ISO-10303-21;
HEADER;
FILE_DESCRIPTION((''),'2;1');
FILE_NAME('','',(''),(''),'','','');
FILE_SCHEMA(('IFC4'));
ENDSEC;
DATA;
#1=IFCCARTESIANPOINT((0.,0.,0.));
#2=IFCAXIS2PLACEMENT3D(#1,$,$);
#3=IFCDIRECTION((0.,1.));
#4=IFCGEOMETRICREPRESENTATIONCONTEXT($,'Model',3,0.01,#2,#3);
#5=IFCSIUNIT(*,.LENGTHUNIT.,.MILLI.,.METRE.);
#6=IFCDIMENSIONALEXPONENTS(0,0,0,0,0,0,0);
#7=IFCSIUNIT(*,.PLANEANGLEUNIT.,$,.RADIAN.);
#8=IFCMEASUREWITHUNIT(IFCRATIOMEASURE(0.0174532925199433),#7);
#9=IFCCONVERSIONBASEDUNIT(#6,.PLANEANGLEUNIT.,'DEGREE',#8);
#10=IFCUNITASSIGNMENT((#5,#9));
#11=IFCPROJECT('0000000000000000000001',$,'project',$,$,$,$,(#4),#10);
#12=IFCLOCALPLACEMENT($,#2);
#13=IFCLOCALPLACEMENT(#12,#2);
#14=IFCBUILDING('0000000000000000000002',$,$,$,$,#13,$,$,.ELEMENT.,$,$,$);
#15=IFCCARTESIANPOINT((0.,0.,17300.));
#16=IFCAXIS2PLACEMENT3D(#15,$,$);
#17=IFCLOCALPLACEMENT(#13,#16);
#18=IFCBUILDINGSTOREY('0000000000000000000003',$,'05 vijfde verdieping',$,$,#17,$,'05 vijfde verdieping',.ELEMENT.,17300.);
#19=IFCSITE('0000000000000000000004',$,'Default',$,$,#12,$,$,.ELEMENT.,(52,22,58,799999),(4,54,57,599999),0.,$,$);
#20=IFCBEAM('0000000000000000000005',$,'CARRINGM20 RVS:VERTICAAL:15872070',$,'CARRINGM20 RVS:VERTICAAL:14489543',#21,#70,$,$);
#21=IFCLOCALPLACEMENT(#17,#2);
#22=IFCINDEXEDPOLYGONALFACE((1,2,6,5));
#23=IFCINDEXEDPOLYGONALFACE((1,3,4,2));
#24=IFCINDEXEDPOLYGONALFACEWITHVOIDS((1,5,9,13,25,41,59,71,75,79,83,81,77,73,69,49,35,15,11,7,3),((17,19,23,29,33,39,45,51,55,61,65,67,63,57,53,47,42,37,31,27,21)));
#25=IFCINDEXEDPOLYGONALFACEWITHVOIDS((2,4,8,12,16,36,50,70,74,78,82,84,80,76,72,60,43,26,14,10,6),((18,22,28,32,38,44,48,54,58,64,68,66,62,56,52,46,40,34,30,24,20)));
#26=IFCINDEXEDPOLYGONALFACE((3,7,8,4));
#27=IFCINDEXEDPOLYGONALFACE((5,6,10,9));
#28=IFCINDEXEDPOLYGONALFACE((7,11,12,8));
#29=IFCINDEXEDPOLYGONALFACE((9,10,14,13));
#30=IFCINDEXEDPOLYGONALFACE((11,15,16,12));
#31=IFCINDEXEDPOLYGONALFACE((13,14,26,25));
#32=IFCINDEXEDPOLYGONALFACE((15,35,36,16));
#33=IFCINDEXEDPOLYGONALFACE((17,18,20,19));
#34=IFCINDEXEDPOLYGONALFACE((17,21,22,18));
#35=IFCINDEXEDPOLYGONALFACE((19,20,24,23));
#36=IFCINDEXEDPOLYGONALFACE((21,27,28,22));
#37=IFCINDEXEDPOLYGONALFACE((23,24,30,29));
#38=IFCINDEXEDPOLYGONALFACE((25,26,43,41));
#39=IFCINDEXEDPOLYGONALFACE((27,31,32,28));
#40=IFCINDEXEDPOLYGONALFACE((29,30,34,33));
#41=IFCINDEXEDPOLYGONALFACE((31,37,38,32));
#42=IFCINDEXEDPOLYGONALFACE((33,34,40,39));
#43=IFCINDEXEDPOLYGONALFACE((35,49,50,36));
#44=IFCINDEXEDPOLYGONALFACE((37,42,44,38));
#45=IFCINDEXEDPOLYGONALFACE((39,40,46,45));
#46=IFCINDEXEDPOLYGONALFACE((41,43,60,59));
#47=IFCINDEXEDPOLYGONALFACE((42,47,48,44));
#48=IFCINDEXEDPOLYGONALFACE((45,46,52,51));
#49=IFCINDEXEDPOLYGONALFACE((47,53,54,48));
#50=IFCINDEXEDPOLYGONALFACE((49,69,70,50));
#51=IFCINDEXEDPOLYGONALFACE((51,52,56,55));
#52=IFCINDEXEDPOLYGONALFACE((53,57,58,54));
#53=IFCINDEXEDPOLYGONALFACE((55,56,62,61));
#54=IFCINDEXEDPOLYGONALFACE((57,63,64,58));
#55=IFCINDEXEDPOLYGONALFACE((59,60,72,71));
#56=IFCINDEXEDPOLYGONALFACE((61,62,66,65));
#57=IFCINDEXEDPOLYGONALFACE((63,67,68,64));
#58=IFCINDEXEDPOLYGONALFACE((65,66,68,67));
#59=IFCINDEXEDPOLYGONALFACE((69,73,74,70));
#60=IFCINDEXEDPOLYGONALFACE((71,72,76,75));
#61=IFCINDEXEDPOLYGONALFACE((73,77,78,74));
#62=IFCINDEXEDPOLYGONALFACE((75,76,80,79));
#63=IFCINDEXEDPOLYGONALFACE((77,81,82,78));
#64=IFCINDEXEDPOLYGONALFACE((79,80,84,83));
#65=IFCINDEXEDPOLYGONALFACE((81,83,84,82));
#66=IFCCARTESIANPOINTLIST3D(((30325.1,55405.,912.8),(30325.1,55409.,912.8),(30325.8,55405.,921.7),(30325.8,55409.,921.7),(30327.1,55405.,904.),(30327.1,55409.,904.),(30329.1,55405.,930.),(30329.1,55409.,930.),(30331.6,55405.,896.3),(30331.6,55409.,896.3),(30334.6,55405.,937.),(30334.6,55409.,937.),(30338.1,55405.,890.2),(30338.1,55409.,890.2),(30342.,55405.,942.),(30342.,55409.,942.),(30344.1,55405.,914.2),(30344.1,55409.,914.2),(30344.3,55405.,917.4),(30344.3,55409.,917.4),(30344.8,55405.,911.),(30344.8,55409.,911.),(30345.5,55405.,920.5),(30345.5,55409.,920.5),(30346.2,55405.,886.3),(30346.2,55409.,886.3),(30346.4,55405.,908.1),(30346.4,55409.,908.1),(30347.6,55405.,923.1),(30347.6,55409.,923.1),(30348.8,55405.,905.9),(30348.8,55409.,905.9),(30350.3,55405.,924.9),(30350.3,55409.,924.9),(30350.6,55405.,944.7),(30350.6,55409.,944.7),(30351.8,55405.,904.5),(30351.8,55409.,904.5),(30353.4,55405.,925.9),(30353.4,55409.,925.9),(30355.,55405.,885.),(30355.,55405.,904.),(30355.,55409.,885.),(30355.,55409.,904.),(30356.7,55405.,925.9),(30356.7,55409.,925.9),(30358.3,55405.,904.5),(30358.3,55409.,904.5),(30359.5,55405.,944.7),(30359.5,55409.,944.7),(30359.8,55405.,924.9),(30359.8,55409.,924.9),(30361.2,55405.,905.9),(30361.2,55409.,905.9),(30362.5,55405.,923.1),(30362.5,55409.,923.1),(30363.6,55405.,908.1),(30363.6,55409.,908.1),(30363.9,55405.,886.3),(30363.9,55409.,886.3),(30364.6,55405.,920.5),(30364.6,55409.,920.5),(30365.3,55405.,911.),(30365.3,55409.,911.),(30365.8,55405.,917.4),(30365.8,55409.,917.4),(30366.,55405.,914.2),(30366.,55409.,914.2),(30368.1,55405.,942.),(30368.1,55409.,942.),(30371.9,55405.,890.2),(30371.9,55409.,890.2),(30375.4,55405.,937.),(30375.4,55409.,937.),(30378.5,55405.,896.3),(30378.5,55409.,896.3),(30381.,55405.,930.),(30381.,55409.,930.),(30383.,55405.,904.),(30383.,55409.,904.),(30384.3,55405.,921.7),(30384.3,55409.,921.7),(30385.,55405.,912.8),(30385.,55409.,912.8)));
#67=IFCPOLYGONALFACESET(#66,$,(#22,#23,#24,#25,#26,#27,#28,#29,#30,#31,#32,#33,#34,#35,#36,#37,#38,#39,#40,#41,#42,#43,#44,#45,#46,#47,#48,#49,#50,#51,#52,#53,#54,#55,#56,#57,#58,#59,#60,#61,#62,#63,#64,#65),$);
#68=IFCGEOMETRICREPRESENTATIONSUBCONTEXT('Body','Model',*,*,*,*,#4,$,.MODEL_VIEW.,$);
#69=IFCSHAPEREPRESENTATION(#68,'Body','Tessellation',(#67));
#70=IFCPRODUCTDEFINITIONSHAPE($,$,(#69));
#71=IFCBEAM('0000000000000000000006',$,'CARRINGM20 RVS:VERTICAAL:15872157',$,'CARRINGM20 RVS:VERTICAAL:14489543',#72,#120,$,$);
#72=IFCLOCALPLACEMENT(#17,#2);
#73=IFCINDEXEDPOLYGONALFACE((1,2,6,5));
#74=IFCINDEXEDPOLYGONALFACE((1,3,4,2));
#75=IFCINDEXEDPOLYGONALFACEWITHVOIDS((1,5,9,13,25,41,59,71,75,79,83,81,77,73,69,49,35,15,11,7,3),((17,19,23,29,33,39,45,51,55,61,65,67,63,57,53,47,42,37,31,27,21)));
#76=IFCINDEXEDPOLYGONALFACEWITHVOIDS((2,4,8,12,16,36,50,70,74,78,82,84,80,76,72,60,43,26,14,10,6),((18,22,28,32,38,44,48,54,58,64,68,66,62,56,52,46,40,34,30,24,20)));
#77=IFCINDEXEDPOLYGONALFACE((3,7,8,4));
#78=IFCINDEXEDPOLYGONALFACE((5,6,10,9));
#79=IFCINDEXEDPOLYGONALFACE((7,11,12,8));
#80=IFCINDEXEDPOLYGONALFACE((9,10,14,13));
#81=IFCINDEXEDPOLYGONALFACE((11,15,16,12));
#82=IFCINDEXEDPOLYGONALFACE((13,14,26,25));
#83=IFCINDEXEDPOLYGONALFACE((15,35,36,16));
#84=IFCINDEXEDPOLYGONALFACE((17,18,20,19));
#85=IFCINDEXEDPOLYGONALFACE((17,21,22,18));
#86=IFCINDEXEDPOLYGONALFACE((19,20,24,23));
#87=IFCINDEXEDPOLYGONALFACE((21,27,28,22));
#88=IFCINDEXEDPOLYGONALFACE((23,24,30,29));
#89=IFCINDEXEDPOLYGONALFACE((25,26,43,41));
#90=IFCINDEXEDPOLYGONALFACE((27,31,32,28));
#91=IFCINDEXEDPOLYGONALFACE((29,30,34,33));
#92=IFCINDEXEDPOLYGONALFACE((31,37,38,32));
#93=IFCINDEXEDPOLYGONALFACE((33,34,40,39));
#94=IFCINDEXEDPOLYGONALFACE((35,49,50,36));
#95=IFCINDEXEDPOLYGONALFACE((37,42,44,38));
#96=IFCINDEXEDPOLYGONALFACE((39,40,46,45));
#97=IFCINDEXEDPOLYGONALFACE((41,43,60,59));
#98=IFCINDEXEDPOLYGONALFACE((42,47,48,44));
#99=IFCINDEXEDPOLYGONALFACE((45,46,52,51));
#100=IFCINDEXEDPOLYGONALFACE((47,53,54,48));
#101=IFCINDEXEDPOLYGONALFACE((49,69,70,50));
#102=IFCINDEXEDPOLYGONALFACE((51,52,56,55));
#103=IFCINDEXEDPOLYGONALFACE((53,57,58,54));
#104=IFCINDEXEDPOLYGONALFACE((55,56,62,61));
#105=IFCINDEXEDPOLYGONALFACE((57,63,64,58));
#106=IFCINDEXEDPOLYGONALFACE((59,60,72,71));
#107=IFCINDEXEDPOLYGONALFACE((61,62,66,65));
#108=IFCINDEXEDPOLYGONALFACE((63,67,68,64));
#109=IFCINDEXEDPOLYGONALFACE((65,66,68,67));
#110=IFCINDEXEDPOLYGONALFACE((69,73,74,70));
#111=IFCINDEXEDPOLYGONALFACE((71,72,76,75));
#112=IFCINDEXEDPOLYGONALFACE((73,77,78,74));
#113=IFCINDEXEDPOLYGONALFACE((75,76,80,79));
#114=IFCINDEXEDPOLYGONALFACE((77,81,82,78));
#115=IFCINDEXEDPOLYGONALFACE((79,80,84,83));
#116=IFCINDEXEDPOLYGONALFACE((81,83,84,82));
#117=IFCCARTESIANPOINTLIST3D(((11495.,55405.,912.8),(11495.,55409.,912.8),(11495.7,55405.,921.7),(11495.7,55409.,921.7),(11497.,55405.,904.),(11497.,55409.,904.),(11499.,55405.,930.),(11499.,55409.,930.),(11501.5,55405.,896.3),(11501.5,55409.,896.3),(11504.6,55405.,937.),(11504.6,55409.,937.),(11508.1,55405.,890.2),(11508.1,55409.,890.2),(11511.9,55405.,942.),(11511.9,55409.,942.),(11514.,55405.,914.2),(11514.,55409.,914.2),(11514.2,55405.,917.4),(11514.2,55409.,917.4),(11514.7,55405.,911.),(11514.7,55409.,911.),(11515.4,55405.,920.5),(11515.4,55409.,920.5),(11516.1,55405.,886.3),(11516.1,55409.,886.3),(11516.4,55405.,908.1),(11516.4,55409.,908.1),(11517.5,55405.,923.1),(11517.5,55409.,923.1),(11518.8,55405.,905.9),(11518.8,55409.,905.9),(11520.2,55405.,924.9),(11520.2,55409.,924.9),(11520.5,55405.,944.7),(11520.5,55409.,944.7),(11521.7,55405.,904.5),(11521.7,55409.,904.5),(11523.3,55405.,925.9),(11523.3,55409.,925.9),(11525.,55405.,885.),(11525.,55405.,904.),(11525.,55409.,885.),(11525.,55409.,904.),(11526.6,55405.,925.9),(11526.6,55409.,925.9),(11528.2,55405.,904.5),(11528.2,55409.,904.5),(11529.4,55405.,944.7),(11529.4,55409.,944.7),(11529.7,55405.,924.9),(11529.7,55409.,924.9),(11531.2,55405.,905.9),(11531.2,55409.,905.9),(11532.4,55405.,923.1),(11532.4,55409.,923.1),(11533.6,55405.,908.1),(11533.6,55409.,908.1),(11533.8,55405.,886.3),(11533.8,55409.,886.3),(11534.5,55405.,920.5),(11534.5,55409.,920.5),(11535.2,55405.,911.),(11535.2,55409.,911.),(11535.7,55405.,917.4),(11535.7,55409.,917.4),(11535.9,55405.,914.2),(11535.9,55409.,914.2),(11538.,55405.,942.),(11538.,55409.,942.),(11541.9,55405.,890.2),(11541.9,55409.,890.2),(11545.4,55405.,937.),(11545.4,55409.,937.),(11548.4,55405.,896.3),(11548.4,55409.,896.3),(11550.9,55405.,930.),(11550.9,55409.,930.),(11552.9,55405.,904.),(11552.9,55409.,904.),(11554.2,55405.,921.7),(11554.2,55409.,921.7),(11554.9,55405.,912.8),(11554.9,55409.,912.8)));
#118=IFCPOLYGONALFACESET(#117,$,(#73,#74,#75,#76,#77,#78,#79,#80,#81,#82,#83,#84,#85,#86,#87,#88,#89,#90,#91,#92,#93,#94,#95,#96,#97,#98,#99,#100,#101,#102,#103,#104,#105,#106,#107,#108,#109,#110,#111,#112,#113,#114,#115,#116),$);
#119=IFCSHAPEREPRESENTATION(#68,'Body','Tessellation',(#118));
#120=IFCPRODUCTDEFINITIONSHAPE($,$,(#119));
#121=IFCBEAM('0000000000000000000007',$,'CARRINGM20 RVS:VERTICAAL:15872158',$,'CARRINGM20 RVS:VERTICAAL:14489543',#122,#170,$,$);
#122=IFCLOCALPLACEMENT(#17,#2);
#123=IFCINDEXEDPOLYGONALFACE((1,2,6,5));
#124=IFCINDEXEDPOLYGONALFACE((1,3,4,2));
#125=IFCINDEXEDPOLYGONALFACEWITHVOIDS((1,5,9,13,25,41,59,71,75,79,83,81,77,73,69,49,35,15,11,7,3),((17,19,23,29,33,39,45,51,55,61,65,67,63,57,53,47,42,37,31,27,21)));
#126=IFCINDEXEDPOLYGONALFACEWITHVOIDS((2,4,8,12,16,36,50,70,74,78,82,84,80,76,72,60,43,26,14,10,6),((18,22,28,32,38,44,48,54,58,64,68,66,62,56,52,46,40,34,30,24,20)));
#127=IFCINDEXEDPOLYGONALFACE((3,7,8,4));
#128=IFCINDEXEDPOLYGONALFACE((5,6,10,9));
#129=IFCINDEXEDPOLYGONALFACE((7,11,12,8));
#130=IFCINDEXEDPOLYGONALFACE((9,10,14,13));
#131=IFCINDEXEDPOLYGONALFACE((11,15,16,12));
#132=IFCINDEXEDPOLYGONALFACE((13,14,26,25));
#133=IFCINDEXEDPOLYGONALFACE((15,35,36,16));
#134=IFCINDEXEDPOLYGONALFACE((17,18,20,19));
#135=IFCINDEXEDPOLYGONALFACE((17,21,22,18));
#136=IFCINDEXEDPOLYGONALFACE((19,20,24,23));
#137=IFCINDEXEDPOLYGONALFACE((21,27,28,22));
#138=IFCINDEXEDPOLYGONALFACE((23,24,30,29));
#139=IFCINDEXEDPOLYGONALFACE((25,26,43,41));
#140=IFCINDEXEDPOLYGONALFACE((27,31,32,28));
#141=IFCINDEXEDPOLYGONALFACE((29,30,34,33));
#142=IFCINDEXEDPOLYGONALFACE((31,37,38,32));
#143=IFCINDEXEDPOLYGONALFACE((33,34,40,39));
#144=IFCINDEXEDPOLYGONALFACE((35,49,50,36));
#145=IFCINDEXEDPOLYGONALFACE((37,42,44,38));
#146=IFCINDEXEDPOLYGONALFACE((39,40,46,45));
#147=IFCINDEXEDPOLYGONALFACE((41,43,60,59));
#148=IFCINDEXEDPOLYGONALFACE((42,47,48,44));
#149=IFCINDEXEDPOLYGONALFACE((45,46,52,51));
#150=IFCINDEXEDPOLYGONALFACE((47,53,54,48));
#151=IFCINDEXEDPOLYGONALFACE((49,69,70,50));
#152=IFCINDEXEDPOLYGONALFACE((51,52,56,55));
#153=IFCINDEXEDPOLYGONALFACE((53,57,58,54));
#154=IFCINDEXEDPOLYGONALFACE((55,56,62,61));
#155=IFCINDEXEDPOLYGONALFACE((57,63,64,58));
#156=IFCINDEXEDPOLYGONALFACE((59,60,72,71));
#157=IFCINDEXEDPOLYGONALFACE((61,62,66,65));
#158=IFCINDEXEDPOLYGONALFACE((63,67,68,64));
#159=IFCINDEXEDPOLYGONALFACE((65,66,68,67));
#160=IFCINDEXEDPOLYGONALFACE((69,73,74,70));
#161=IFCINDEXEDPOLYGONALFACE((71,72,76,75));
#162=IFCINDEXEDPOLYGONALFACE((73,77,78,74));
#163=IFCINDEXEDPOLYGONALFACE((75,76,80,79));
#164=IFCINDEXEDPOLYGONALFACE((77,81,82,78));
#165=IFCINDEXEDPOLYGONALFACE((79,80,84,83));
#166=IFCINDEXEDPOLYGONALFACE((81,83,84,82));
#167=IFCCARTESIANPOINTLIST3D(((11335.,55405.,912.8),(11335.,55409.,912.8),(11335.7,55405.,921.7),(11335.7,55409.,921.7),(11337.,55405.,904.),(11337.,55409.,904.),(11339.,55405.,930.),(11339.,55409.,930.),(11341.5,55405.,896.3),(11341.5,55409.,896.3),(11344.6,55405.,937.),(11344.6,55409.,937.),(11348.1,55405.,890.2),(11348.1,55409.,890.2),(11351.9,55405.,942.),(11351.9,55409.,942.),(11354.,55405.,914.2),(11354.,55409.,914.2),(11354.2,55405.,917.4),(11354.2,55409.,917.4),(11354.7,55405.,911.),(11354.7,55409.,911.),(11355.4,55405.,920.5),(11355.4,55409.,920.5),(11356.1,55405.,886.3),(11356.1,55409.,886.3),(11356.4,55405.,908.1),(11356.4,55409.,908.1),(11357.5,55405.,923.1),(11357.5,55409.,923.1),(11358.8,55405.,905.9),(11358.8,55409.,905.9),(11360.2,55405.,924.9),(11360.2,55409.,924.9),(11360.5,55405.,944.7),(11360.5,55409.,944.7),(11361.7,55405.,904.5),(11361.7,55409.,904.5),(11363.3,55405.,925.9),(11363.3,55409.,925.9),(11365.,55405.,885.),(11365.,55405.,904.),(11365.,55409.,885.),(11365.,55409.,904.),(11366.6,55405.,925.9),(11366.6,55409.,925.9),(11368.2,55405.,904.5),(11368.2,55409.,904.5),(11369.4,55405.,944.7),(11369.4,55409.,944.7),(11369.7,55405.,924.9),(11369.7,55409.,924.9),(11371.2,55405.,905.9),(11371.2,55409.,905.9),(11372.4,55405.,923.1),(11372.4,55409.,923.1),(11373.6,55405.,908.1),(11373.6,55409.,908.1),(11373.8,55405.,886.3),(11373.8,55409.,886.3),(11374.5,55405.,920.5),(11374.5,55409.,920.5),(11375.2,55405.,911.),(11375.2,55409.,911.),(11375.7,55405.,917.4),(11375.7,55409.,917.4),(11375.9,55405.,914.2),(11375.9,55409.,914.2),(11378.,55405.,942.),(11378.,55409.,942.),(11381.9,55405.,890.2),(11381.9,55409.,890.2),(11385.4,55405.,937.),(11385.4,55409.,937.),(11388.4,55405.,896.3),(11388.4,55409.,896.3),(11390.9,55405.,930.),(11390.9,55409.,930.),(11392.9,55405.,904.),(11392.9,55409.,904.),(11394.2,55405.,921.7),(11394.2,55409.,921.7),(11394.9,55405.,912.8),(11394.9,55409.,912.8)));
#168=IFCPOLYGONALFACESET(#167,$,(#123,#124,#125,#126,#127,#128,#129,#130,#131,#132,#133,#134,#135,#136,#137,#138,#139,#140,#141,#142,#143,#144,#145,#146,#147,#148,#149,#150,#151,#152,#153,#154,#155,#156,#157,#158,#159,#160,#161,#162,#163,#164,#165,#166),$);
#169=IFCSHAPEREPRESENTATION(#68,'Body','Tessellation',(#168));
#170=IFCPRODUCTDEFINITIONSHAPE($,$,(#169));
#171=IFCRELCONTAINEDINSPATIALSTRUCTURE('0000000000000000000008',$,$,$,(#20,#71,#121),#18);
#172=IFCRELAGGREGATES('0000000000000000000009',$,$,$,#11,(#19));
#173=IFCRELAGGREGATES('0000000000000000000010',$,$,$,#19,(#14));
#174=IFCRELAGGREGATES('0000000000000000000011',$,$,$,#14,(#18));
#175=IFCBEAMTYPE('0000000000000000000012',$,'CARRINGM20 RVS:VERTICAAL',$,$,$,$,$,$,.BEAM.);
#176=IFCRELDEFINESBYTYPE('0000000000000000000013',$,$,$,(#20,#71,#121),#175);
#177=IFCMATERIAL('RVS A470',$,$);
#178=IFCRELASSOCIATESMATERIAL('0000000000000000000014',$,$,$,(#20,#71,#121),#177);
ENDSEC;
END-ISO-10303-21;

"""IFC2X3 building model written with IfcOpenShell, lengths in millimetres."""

from ifc_helpers import new_model, entity, si_unit, converted_unit, direction, frame, origin, origin_2d_with_axis, place, context, subcontext, project, spatial, hollow_circle, extrude, material, type_object, element, save


model = new_model("IFC2X3")

# Units and contexts
model_context = context("Model", 3, precision=0.01, world=origin(), true_north=direction((0.0, 1.0)))
body_context = subcontext(model_context, "Body", "Model", "MODEL_VIEW")
ifc_project = project(units=[si_unit("LENGTHUNIT", "METRE", prefix="MILLI"), converted_unit("PLANEANGLEUNIT", "DEGREE", entity("IfcRatioMeasure", 0.0174532925199433), si_unit("PLANEANGLEUNIT", "RADIAN"), dimensions=[0, 0, 0, 0, 0, 0, 0])], contexts=[model_context])

# Site, building, storey
site_placement = place(None, origin())
site = spatial("IfcSite", under=ifc_project, at=site_placement, Name="Default", CompositionType="ELEMENT", RefLatitude=(52, 22, 58, 799999), RefLongitude=(4, 54, 57, 599999), RefElevation=0.0)
building_placement = place(site_placement, origin())
building = spatial("IfcBuilding", under=site, at=building_placement, CompositionType="ELEMENT")
storey_placement = place(building_placement, frame((0.0, 0.0, 17300.0)))
storey = spatial("IfcBuildingStorey", under=building, at=storey_placement, Name="05 vijfde verdieping", LongName="05 vijfde verdieping", CompositionType="ELEMENT", Elevation=17300.0)

# Beams
ifc_material_1 = material(Name="RVS A470")
beam_type_1 = type_object("IfcBeamType", Name="CARRINGM20 RVS:VERTICAAL", PredefinedType="BEAM")
beam_1_placement = place(storey_placement, origin())
element("IfcBeam", 1, at=beam_1_placement, inside=storey, type_object=beam_type_1, material=ifc_material_1, Name="CARRINGM20 RVS:VERTICAAL:15872070", ObjectType="CARRINGM20 RVS:VERTICAAL:14489543", context=body_context, shape_type="SweptSolid", body=[
    extrude(hollow_circle(Radius=30.0, WallThickness=19.0, at=origin_2d_with_axis()), frame((30355.0, 55405.0, 915.0), z_axis=(0.0, 1.0, 0.0), x_axis=(0.0, 0.0, -1.0)), (0.0, 0.0, 1.0), 4.0),
])
beam_2_placement = place(storey_placement, origin())
element("IfcBeam", 2, at=beam_2_placement, inside=storey, type_object=beam_type_1, material=ifc_material_1, Name="CARRINGM20 RVS:VERTICAAL:15872157", ObjectType="CARRINGM20 RVS:VERTICAAL:14489543", context=body_context, shape_type="SweptSolid", body=[
    extrude(hollow_circle(Radius=30.0, WallThickness=19.0, at=origin_2d_with_axis()), frame((11525.0, 55405.0, 915.0), z_axis=(0.0, 1.0, 0.0), x_axis=(0.0, 0.0, -1.0)), (0.0, 0.0, 1.0), 4.0),
])
beam_3_placement = place(storey_placement, origin())
element("IfcBeam", 3, at=beam_3_placement, inside=storey, type_object=beam_type_1, material=ifc_material_1, Name="CARRINGM20 RVS:VERTICAAL:15872158", ObjectType="CARRINGM20 RVS:VERTICAAL:14489543", context=body_context, shape_type="SweptSolid", body=[
    extrude(hollow_circle(Radius=30.0, WallThickness=19.0, at=origin_2d_with_axis()), frame((11365.0, 55405.0, 915.0), z_axis=(0.0, 1.0, 0.0), x_axis=(0.0, 0.0, -1.0)), (0.0, 0.0, 1.0), 4.0),
])

save(model, "model.ifc")
